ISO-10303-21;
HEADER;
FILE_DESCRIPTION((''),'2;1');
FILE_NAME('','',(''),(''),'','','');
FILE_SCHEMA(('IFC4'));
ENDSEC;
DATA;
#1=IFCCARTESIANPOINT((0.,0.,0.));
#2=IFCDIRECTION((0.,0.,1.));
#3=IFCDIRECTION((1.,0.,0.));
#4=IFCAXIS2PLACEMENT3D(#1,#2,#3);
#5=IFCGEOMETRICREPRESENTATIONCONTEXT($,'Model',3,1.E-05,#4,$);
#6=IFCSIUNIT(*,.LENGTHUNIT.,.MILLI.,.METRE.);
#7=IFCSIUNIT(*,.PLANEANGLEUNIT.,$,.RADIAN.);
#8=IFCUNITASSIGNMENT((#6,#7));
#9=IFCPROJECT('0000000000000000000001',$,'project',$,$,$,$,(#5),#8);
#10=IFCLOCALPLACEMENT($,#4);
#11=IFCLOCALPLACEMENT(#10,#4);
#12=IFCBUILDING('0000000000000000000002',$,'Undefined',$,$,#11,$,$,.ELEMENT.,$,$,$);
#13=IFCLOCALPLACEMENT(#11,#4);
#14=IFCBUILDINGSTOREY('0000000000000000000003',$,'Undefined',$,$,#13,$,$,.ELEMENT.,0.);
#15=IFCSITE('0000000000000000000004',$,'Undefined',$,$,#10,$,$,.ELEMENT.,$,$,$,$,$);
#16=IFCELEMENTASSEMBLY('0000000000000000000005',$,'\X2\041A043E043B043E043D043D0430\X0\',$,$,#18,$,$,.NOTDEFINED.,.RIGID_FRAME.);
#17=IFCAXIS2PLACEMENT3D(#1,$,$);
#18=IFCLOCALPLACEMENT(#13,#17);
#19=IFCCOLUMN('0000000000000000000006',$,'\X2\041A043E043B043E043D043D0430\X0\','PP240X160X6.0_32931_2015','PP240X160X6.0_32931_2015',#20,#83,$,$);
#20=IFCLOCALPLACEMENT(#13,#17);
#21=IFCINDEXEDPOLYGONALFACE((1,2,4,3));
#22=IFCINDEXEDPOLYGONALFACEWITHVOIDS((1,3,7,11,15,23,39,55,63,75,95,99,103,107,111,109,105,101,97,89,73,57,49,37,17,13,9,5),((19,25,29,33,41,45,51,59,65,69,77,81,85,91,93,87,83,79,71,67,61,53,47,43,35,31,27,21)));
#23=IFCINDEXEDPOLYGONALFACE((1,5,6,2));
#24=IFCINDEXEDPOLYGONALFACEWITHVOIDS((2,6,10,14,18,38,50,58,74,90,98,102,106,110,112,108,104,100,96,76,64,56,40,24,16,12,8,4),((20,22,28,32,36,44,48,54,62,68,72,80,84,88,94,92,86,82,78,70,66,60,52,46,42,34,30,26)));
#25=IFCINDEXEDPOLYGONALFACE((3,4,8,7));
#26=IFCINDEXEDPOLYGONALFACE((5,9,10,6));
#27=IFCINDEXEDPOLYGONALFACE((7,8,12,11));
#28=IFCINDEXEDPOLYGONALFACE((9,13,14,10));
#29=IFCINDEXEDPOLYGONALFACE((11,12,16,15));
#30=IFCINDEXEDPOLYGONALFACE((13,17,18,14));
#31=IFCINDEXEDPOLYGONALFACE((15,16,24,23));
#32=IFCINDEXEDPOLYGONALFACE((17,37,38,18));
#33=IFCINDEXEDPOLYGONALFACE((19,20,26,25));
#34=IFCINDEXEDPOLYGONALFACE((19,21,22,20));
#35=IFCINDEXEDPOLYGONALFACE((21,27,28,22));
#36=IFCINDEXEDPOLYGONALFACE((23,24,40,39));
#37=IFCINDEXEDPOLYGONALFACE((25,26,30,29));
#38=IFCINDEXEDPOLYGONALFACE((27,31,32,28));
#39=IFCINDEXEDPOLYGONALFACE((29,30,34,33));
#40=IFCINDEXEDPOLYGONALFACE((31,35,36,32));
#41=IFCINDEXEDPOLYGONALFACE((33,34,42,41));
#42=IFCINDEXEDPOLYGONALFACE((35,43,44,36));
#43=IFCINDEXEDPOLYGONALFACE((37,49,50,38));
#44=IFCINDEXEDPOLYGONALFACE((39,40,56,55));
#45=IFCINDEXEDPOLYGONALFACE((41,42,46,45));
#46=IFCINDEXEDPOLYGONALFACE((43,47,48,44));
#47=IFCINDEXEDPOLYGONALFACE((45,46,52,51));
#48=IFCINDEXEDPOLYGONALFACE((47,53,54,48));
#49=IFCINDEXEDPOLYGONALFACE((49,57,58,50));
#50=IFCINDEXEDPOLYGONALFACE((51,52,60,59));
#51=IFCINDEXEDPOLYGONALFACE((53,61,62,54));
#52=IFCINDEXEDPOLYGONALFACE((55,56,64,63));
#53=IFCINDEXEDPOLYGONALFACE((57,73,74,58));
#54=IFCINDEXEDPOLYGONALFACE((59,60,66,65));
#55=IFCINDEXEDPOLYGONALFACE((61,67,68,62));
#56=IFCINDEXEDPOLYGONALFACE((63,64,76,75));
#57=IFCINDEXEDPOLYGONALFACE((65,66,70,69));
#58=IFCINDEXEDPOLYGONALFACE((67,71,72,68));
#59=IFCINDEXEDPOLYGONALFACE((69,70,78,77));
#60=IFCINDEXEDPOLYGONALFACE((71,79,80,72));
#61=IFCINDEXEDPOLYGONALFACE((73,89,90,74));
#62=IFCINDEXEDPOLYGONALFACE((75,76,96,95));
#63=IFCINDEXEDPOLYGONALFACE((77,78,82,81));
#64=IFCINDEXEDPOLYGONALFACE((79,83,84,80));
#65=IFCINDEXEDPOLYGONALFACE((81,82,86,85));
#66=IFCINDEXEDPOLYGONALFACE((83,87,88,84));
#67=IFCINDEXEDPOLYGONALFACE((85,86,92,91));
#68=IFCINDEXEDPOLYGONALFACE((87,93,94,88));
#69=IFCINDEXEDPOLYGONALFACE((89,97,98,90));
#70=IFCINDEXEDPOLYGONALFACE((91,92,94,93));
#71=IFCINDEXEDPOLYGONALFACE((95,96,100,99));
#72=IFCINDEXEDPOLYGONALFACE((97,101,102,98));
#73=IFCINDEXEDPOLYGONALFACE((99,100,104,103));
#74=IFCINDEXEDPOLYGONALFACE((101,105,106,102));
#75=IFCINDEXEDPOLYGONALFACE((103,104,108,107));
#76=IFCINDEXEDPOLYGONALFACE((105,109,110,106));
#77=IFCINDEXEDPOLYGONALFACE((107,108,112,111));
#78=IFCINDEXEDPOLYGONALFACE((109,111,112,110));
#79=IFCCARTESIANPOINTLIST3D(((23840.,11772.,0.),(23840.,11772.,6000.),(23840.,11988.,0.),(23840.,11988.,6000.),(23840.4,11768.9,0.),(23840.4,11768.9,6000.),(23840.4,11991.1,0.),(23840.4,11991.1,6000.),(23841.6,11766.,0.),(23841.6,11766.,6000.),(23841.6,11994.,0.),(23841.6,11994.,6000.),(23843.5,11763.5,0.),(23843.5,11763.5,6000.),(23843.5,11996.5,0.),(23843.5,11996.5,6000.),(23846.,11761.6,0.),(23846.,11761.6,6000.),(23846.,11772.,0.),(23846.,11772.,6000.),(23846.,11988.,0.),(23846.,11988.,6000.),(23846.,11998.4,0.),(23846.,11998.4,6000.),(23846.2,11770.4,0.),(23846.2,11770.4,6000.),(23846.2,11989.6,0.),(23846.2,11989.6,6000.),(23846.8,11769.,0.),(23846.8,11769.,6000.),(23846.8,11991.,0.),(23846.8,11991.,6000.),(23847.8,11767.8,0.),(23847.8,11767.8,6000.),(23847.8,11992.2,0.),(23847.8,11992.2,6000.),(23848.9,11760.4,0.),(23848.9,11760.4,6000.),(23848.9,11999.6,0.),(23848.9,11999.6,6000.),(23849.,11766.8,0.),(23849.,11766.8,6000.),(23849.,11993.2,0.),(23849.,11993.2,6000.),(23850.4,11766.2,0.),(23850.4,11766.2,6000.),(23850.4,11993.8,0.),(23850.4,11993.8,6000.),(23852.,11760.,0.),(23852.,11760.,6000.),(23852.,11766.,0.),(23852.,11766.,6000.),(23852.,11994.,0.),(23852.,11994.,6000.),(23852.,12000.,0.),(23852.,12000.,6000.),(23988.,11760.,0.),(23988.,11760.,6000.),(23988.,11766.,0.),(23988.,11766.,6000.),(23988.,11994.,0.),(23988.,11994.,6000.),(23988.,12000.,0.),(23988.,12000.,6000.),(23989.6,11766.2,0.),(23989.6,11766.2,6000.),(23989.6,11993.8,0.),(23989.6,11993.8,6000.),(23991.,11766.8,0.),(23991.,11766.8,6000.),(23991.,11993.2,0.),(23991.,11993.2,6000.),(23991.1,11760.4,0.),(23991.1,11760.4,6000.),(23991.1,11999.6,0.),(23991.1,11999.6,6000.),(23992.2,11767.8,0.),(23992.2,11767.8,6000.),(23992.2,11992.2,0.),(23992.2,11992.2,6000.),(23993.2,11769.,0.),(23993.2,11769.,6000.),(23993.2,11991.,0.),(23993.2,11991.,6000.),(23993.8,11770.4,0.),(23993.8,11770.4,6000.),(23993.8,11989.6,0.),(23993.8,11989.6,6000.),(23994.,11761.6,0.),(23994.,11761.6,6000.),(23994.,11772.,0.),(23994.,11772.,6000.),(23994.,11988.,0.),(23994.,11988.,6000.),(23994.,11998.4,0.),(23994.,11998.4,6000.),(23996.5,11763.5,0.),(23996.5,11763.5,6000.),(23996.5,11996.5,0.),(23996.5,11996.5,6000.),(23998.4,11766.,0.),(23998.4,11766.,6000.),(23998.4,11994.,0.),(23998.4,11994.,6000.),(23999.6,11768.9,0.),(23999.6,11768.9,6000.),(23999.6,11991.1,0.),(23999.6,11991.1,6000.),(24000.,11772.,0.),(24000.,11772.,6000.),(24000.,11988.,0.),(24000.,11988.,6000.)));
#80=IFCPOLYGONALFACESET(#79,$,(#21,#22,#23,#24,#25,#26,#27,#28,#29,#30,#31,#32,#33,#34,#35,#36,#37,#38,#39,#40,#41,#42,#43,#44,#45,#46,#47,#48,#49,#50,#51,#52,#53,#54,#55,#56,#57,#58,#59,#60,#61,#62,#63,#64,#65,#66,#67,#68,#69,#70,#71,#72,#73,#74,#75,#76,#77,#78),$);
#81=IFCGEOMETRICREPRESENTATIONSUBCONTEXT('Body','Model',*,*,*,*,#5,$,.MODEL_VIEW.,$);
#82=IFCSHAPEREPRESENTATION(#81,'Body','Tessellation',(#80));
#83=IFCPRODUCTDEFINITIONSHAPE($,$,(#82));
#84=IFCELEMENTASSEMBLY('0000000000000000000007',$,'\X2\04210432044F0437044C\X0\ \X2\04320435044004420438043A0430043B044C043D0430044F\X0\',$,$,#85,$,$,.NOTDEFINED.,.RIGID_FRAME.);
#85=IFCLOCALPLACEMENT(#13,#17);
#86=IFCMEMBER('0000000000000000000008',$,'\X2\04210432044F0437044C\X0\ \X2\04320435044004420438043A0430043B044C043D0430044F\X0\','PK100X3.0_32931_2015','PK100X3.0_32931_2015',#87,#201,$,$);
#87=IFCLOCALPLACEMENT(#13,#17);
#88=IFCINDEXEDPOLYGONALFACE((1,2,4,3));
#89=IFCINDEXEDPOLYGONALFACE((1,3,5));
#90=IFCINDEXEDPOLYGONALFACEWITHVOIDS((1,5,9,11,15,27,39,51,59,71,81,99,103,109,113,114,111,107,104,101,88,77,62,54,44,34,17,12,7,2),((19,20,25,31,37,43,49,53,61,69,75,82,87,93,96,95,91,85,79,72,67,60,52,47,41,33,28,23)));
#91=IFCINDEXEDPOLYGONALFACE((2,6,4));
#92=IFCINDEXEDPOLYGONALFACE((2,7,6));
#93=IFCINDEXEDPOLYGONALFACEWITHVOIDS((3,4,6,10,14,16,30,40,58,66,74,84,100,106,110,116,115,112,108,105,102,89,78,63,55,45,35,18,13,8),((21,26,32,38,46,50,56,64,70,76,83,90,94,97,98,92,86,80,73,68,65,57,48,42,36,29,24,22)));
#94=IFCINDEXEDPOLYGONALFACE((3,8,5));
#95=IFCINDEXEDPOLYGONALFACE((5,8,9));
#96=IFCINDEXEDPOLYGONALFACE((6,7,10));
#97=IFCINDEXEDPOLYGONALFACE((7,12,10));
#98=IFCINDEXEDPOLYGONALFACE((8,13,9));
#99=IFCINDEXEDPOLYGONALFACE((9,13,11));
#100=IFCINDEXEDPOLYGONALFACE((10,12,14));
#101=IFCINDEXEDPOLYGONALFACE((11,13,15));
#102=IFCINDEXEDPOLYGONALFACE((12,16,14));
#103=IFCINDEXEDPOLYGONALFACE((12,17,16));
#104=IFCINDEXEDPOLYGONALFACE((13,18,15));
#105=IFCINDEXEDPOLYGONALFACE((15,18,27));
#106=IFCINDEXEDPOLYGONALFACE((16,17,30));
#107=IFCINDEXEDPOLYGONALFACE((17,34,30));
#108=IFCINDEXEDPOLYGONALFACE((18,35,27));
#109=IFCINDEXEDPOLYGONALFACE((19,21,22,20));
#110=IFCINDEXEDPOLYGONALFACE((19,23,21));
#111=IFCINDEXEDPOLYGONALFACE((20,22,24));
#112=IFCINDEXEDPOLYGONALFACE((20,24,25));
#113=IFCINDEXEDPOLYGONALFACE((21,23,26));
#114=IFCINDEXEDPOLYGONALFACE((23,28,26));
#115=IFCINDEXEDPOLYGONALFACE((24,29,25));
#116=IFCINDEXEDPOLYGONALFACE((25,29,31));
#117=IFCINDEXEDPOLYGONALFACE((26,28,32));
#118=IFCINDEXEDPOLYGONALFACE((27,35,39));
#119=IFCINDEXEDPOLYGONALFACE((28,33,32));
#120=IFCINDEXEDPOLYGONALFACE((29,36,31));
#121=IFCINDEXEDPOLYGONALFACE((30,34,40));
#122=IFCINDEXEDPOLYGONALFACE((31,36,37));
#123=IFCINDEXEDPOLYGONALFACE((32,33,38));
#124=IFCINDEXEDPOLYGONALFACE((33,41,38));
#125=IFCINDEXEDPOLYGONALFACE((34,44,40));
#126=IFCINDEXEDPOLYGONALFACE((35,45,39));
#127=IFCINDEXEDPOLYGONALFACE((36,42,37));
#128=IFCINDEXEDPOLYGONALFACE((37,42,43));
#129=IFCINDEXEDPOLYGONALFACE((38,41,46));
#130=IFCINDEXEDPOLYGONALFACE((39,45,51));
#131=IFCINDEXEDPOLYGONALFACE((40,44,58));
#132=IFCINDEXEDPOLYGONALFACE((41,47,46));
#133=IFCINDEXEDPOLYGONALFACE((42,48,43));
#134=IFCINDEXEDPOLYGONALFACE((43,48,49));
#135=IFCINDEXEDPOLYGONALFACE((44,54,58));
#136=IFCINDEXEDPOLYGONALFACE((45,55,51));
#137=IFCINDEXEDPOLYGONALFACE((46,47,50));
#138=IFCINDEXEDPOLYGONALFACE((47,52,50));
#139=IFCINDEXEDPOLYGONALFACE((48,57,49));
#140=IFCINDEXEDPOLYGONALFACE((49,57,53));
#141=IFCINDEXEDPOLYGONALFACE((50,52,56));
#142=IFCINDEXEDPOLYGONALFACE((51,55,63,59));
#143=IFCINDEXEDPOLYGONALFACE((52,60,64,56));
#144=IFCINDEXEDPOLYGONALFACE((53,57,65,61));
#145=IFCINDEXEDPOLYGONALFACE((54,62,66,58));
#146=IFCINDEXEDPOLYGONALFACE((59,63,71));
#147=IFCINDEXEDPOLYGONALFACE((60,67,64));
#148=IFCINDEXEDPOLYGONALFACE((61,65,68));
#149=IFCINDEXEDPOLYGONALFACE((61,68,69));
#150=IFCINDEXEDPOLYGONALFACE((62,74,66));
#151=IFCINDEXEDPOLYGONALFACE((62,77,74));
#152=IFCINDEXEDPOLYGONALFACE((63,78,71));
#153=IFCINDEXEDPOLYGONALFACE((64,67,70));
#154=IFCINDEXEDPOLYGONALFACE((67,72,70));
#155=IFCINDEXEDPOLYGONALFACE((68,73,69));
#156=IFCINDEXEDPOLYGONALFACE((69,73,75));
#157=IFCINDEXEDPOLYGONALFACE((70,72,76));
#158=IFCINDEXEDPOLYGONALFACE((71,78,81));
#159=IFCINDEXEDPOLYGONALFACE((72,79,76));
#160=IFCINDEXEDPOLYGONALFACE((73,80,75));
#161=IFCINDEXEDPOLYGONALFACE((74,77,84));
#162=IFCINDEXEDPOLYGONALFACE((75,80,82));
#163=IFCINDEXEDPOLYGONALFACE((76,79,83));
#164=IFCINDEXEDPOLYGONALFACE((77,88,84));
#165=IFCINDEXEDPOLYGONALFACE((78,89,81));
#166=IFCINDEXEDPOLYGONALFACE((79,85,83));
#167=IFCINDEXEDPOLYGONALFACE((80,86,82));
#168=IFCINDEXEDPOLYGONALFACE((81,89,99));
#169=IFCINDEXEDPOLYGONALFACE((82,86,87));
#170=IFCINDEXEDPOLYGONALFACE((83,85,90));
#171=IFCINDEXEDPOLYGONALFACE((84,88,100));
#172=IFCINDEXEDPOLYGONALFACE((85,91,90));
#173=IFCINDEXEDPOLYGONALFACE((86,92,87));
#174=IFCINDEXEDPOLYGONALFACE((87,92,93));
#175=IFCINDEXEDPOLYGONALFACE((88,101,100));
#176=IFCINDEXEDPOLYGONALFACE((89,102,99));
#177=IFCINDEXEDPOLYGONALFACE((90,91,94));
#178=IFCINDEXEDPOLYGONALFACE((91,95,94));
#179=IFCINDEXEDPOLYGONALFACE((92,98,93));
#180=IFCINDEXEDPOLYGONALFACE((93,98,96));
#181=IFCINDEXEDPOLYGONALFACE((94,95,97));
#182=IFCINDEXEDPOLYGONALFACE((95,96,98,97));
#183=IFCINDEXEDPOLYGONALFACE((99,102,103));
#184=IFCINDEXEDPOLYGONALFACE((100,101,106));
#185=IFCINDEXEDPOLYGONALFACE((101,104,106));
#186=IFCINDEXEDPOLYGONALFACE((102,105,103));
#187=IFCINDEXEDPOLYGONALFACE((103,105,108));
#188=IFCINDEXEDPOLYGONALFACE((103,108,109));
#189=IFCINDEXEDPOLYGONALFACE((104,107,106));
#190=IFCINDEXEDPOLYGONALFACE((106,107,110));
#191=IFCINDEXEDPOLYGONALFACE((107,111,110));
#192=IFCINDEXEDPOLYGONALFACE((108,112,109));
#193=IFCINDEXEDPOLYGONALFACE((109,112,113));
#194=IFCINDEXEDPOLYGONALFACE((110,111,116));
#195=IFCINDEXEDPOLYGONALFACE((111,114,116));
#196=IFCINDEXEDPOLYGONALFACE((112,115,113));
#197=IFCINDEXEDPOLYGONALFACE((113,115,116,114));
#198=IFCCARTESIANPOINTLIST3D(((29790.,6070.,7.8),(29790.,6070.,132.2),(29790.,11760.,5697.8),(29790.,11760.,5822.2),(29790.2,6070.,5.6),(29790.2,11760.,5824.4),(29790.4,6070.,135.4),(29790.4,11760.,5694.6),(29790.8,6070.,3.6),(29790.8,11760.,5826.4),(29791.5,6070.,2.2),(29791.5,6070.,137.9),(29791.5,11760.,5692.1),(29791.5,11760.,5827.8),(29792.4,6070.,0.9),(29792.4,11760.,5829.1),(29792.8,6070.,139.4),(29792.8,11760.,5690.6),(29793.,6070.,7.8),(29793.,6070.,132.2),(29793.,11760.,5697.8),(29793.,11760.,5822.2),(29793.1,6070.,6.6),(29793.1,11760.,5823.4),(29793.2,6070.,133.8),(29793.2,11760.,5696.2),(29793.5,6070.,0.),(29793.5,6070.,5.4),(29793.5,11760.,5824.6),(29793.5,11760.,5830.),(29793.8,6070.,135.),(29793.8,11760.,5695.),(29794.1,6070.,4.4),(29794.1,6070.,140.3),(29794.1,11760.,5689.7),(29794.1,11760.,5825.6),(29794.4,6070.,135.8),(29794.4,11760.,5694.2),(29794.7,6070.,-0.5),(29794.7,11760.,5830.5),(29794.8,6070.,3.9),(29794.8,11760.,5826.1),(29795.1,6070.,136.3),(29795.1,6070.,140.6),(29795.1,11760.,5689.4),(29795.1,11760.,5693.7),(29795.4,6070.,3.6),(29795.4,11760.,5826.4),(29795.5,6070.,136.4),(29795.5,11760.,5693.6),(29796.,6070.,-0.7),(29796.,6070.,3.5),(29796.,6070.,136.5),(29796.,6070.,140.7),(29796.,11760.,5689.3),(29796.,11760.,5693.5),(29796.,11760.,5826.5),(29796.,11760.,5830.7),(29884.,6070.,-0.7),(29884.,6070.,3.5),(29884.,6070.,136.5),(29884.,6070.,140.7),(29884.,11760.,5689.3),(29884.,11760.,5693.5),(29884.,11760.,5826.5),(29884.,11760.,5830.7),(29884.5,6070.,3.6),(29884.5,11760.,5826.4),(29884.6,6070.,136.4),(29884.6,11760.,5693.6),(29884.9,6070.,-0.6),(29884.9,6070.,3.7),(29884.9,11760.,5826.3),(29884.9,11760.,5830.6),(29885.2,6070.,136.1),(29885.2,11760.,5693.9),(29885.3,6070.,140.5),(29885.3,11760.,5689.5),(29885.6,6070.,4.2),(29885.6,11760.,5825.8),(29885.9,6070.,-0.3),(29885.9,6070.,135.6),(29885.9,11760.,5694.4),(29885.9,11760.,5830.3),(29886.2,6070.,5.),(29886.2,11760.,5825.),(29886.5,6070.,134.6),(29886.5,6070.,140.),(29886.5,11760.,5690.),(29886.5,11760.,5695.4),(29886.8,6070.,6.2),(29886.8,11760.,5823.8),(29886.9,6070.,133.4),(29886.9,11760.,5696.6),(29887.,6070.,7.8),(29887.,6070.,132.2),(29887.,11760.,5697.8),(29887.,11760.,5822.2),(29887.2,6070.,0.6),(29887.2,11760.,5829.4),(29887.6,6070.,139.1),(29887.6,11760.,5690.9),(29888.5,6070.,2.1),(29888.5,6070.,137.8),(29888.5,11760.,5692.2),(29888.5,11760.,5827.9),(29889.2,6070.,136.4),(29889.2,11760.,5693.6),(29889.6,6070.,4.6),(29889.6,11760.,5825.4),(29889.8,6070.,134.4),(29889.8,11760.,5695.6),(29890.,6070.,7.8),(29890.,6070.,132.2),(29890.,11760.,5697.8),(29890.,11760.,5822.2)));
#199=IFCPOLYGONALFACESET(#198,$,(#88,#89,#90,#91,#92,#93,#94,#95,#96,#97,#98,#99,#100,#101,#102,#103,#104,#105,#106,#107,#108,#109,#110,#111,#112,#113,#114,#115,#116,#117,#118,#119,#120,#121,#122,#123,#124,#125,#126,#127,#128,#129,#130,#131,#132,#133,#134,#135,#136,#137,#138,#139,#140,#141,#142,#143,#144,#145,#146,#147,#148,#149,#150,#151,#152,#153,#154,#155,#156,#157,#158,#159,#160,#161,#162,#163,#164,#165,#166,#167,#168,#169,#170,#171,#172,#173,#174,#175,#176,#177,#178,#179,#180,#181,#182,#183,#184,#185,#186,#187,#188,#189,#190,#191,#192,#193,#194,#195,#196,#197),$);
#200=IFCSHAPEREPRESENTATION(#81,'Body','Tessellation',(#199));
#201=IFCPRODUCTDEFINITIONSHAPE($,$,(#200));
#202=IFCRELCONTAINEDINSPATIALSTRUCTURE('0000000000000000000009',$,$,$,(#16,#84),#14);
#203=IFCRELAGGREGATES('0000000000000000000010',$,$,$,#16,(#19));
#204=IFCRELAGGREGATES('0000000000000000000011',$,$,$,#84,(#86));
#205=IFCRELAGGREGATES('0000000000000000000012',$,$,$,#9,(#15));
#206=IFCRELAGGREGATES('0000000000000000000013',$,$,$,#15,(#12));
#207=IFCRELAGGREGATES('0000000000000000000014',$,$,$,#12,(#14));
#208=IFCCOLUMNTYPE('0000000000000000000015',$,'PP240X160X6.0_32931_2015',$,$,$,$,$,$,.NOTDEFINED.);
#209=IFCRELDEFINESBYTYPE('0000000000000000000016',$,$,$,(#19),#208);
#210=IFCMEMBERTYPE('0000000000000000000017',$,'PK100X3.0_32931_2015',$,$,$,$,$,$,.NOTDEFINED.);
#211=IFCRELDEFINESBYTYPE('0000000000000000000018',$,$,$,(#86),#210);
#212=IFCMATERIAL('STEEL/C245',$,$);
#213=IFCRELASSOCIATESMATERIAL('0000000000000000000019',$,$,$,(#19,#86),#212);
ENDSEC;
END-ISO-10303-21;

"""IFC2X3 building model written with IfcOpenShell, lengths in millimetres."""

from ifc_helpers import new_model, si_unit, frame, origin_with_axes, origin_2d_with_axis, place, context, subcontext, project, spatial, hollow_rectangle, extrude, clip, halfspace, material, type_object, element, aggregate, save


model = new_model("IFC2X3")

# Units and contexts
model_context = context("Model", 3, precision=1e-05, world=origin_with_axes())
body_context = subcontext(model_context, "Body", "Model", "MODEL_VIEW")
ifc_project = project(units=[si_unit("LENGTHUNIT", "METRE", prefix="MILLI"), si_unit("PLANEANGLEUNIT", "RADIAN")], contexts=[model_context])

# Site, building, storey
site_placement = place(None, origin_with_axes())
site = spatial("IfcSite", under=ifc_project, at=site_placement, Name="Undefined", CompositionType="ELEMENT")
building_placement = place(site_placement, origin_with_axes())
building = spatial("IfcBuilding", under=site, at=building_placement, Name="Undefined", CompositionType="ELEMENT")
storey_placement = place(building_placement, origin_with_axes())
storey = spatial("IfcBuildingStorey", under=building, at=storey_placement, Name="Undefined", CompositionType="ELEMENT", Elevation=0.0)

# Element assembly, column
ifc_material = material(Name="STEEL/C245")
column_type_1 = type_object("IfcColumnType", Name="PP240X160X6.0_32931_2015", PredefinedType="NOTDEFINED")
assembly_1_placement = place(storey_placement, origin_with_axes())
assembly_1 = element("IfcElementAssembly", 1, at=assembly_1_placement, inside=storey, Name="Колонна", AssemblyPlace="NOTDEFINED", PredefinedType="RIGID_FRAME")
column_1_placement = place(assembly_1_placement, frame((23920.0, 11880.0, 0.0), z_axis=(0.0, 0.0, 1.0), x_axis=(0.0, -1.0, 0.0)))
column_1 = element("IfcColumn", 2, at=column_1_placement, type_object=column_type_1, material=ifc_material, Name="Колонна", Description="PP240X160X6.0_32931_2015", ObjectType="PP240X160X6.0_32931_2015", context=body_context, shape_type="SweptSolid", body=[
    extrude(hollow_rectangle(XDim=160.0, YDim=240.0, WallThickness=6.0, InnerFilletRadius=6.0, OuterFilletRadius=12.0, at=origin_2d_with_axis()), frame((0.0, 0.0, 6000.0), z_axis=(0.0, 0.0, -1.0), x_axis=(0.0, 1.0, 0.0)), (0.0, 0.0, 1.0), 6000.0),
])
aggregate(assembly_1, [column_1])

# Element assembly, member
assembly_2_placement = place(storey_placement, origin_with_axes())
assembly_2 = element("IfcElementAssembly", 3, at=assembly_2_placement, inside=storey, Name="Связь вертикальная", AssemblyPlace="NOTDEFINED", PredefinedType="RIGID_FRAME")
member_type_1 = type_object("IfcMemberType", Name="PK100X3.0_32931_2015", PredefinedType="NOTDEFINED")
member_1_placement = place(assembly_2_placement, frame((29840.0, 6000.0, 0.0), z_axis=(0.0, -0.707107, 0.707107), x_axis=(0.0, 0.707107, 0.707107)))
member_1 = element("IfcMember", 4, at=member_1_placement, type_object=member_type_1, material=ifc_material, Name="Связь вертикальная", Description="PK100X3.0_32931_2015", ObjectType="PK100X3.0_32931_2015", context=body_context, shape_type="Clipping", body=[
    clip(clip(extrude(hollow_rectangle(XDim=100.0, YDim=100.0, WallThickness=3.0, InnerFilletRadius=3.0, OuterFilletRadius=6.0, at=origin_2d_with_axis()), frame((8246.9, 0.0, 0.0), z_axis=(-1.0, 0.0, 0.0), x_axis=(0.0, -1.0, 0.0)), (0.0, 0.0, 1.0), 8248.9), halfspace(frame((8016.6, 0.0, -129.3), z_axis=(-0.707107, 0.0, 0.707107), x_axis=(-0.707107, 0.0, -0.707107)), True)), halfspace(frame((186.9, 0.0, 87.9), z_axis=(0.707107, 0.0, -0.707107), x_axis=(0.707107, 0.0, 0.707107)), True)),
])
aggregate(assembly_2, [member_1])

save(model, "model.ifc")
